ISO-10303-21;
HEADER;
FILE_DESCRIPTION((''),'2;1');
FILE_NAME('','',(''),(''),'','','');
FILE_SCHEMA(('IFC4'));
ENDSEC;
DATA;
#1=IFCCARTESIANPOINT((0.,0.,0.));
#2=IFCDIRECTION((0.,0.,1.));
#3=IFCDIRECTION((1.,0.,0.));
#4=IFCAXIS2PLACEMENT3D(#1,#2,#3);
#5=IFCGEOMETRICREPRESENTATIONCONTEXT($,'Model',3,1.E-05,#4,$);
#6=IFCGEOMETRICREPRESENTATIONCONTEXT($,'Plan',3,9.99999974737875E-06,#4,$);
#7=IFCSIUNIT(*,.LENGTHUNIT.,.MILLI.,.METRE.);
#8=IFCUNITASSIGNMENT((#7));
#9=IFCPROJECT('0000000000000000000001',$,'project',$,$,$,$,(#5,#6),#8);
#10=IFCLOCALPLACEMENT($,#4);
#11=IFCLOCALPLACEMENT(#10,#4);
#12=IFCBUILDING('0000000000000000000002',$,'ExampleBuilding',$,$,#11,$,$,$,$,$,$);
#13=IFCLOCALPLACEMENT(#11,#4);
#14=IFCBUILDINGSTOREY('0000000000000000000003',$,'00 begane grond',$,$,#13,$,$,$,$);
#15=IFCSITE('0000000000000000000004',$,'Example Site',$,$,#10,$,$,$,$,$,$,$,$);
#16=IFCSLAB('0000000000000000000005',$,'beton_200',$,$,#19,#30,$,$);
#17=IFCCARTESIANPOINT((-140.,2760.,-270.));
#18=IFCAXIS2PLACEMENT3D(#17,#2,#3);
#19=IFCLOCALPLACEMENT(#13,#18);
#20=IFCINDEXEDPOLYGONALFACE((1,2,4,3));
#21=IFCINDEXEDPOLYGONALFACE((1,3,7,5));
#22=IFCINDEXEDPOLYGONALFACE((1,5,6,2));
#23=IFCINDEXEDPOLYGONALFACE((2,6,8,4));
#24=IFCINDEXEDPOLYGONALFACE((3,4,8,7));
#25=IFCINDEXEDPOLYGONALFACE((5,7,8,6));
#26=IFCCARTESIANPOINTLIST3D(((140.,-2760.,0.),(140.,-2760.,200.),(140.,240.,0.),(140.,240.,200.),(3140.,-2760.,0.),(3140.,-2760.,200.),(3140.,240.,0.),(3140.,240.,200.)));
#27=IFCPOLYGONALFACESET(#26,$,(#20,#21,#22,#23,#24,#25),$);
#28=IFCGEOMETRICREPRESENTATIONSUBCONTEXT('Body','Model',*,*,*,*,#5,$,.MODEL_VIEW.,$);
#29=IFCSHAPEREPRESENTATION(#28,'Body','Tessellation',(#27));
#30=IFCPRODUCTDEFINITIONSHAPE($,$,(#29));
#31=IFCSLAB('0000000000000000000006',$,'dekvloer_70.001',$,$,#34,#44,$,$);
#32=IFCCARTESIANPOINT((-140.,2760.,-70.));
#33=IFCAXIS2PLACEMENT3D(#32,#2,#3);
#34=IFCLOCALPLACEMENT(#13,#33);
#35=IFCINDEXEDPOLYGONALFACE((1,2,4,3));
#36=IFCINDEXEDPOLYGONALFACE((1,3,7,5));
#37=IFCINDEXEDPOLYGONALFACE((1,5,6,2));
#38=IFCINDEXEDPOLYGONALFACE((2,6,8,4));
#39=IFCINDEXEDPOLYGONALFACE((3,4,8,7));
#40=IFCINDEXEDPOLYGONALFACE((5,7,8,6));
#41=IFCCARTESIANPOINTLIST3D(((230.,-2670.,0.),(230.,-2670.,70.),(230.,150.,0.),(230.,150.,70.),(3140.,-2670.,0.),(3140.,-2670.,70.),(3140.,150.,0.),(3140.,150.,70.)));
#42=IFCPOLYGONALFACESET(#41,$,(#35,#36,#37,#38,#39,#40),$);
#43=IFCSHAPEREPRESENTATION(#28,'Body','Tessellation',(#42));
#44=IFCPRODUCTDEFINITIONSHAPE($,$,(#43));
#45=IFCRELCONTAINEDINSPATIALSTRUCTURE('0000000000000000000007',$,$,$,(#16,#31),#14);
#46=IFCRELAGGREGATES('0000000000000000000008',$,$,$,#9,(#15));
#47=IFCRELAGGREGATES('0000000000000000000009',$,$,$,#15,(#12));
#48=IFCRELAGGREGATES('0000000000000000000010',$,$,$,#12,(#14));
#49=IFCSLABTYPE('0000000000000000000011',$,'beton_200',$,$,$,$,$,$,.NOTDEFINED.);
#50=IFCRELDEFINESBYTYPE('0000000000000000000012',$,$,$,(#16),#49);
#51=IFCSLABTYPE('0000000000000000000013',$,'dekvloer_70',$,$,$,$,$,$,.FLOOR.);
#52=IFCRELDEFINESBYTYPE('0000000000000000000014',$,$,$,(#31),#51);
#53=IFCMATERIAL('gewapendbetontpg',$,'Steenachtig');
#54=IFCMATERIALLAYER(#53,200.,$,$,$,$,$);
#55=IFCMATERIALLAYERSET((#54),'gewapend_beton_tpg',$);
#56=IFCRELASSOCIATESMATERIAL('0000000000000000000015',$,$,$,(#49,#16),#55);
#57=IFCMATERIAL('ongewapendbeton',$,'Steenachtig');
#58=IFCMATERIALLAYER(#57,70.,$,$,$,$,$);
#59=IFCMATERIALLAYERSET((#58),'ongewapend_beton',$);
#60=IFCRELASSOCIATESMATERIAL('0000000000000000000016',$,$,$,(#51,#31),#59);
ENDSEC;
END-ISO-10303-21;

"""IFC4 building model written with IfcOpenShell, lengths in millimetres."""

from ifc_helpers import new_model, si_unit, frame, origin_with_axes, place, context, subcontext, project, spatial, indexed_curve, outline, extrude, material, layer, layer_set, layer_usage, type_object, element, save


model = new_model("IFC4")

# Units and contexts
model_context = context("Model", 3, precision=1e-05, world=origin_with_axes())
plan_context = context("Plan", 3, precision=9.99999974737875e-06, world=origin_with_axes())
body_context = subcontext(model_context, "Body", "Model", "MODEL_VIEW")
ifc_project = project(units=[si_unit("LENGTHUNIT", "METRE", prefix="MILLI")], contexts=[model_context, plan_context])

# Site, building, storey
site_placement = place(None, frame((0.0, 0.0, 0.0), z_axis=(0.0, 0.0, 1.0), x_axis=(1.0, 0.0, 0.0)))
site = spatial("IfcSite", under=ifc_project, at=site_placement, Name="Example Site")
building_placement = place(site_placement, frame((0.0, 0.0, 0.0), z_axis=(0.0, 0.0, 1.0), x_axis=(1.0, 0.0, 0.0)))
building = spatial("IfcBuilding", under=site, at=building_placement, Name="ExampleBuilding")
storey_placement = place(building_placement, frame((0.0, 0.0, 0.0), z_axis=(0.0, 0.0, 1.0), x_axis=(1.0, 0.0, 0.0)))
storey = spatial("IfcBuildingStorey", under=building, at=storey_placement, Name="00 begane grond")

# Slabs
ifc_material_1 = material(Name="gewapendbetontpg", Category="Steenachtig")
ifc_layer_1 = layer(ifc_material_1, 200.0)
ifc_layer_set_1 = layer_set([ifc_layer_1], Name="gewapend_beton_tpg")
ifc_layer_usage_1 = layer_usage(ifc_layer_set_1, "AXIS3", "POSITIVE", 0.0)
slab_type_1 = type_object("IfcSlabType", Name="beton_200", PredefinedType="NOTDEFINED", material=ifc_layer_set_1)
slab_1_placement = place(storey_placement, frame((-140.0, 2760.0, -270.0), z_axis=(0.0, 0.0, 1.0), x_axis=(1.0, 0.0, 0.0)))
element("IfcSlab", 1, at=slab_1_placement, inside=storey, type_object=slab_type_1, material=ifc_layer_usage_1, Name="beton_200", context=body_context, shape_type="SweptSolid", body=[
    extrude(outline(indexed_curve([(140.0, 240.0), (140.0, -2760.0), (3140.0, -2760.0), (3140.0, 240.0), (140.0, 240.0)])), None, (0.0, 0.0, 1.0), 200.0),
])
ifc_material_2 = material(Name="ongewapendbeton", Category="Steenachtig")
ifc_layer_2 = layer(ifc_material_2, 70.0)
ifc_layer_set_2 = layer_set([ifc_layer_2], Name="ongewapend_beton")
ifc_layer_usage_2 = layer_usage(ifc_layer_set_2, "AXIS3", "POSITIVE", 0.0)
slab_type_2 = type_object("IfcSlabType", Name="dekvloer_70", PredefinedType="FLOOR", material=ifc_layer_set_2)
slab_2_placement = place(storey_placement, frame((-140.0, 2760.0, -70.0), z_axis=(0.0, 0.0, 1.0), x_axis=(1.0, 0.0, 0.0)))
element("IfcSlab", 2, at=slab_2_placement, inside=storey, type_object=slab_type_2, material=ifc_layer_usage_2, Name="dekvloer_70.001", context=body_context, shape_type="SweptSolid", body=[
    extrude(outline(indexed_curve([(3140.0, -2670.0), (230.0, -2670.0), (230.0, 150.0), (3140.0, 150.0), (3140.0, -2670.0)])), None, (0.0, 0.0, 1.0), 70.0),
])

save(model, "model.ifc")
